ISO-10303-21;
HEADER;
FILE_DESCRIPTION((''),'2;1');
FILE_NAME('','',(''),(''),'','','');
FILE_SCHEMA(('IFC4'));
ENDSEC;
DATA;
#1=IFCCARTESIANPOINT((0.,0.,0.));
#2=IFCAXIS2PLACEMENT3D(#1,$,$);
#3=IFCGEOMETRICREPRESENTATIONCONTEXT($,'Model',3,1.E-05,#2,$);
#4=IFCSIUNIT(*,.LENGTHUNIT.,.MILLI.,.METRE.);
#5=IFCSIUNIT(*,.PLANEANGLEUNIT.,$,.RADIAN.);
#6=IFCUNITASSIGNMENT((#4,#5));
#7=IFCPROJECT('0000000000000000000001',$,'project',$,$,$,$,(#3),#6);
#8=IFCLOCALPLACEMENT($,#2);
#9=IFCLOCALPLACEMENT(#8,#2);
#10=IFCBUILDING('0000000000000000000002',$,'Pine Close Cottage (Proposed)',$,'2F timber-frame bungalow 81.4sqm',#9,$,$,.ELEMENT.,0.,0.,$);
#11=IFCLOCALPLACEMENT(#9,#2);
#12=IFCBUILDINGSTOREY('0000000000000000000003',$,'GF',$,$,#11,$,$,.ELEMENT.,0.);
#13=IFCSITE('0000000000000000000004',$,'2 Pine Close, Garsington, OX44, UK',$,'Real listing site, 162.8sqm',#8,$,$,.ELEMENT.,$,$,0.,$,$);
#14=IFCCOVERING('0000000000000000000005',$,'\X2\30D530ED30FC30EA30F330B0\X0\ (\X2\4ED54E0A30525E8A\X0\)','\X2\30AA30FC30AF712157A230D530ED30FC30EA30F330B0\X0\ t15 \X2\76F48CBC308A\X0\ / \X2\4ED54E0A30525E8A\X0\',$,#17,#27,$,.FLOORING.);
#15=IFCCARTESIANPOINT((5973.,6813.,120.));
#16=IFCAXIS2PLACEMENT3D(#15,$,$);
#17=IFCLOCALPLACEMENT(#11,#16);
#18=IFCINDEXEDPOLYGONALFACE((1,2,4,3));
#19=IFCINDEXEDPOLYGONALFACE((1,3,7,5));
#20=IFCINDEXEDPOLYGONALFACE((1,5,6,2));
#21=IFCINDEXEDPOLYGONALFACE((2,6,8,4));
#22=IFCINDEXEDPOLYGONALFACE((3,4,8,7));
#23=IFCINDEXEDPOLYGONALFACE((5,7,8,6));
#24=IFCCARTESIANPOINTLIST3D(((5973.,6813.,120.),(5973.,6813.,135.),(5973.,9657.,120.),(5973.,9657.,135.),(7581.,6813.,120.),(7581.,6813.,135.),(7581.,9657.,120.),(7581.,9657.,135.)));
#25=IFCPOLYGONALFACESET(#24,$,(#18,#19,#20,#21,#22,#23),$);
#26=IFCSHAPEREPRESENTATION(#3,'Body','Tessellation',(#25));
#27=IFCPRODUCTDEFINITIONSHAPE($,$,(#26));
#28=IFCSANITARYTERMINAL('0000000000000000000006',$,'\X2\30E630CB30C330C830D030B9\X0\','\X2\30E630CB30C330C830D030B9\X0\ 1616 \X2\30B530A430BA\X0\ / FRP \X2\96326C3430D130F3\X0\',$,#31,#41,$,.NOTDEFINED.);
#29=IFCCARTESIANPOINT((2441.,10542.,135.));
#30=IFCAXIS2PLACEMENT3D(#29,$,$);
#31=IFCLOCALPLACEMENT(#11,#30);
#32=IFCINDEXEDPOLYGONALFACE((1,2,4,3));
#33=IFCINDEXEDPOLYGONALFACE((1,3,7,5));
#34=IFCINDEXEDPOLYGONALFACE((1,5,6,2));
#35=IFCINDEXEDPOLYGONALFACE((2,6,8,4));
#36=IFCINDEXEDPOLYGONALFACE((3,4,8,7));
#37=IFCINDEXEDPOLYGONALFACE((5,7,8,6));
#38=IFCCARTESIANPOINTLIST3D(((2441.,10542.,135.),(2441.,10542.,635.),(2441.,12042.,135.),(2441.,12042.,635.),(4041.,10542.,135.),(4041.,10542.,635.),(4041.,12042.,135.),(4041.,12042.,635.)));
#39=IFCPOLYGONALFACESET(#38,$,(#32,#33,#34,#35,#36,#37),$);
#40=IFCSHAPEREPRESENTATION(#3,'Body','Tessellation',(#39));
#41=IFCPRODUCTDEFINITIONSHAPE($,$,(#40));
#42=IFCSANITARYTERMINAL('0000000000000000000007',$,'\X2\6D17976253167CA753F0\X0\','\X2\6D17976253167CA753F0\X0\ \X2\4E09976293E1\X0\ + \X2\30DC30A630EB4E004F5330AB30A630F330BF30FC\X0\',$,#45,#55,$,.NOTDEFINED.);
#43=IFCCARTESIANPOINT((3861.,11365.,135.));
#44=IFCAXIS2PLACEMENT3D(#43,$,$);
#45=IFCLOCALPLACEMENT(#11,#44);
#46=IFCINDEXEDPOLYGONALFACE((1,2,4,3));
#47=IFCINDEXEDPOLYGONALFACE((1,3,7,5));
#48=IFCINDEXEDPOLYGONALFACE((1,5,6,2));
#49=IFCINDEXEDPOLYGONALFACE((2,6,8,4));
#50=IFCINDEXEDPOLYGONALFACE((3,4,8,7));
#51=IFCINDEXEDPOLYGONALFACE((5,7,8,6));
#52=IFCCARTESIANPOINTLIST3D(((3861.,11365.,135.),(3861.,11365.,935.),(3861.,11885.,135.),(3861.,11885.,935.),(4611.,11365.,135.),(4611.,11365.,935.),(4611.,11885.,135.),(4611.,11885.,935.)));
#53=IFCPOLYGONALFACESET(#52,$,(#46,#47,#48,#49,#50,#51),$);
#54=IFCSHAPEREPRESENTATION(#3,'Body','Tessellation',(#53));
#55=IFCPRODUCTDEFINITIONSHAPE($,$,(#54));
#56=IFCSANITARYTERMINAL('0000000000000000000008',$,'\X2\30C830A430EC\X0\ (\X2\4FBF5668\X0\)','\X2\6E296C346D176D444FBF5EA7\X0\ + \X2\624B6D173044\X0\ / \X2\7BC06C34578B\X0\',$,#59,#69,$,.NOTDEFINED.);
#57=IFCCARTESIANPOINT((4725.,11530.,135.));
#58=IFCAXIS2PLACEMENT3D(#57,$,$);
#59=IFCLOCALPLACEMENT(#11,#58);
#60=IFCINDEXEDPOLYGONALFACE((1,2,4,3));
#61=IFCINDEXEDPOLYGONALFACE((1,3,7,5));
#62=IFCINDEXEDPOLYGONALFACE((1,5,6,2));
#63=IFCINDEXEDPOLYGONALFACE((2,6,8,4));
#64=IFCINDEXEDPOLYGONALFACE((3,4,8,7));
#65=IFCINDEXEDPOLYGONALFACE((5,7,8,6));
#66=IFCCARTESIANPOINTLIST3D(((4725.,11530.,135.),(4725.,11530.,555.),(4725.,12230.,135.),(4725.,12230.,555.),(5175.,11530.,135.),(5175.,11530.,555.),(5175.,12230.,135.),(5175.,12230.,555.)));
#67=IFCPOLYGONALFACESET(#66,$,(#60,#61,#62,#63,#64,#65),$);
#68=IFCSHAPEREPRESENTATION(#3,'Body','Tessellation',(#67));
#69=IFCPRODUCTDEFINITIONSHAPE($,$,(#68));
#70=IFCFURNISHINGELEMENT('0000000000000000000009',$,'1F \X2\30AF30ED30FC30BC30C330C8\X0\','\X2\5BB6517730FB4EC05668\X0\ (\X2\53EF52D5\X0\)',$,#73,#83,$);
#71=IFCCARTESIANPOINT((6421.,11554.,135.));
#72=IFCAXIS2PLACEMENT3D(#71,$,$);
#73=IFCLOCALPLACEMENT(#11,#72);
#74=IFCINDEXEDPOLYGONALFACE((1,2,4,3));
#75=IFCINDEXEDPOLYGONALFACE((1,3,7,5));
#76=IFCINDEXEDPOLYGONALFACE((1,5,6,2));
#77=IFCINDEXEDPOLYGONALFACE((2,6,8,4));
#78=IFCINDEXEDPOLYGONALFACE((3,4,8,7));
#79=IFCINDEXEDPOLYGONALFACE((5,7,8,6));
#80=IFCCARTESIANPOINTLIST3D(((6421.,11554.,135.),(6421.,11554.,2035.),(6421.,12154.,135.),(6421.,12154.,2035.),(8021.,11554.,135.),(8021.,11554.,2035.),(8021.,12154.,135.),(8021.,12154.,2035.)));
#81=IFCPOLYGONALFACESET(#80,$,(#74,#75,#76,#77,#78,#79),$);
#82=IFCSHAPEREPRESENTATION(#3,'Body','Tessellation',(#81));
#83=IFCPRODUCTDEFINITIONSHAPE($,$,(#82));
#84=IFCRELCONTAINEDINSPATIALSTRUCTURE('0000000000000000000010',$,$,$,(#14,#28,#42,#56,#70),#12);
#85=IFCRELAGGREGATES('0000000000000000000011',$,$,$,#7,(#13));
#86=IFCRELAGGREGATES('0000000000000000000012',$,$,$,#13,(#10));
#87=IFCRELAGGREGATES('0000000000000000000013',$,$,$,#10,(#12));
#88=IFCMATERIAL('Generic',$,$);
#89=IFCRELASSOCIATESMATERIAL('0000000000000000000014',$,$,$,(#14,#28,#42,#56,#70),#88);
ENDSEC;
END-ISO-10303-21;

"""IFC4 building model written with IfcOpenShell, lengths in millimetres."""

from ifc_helpers import new_model, si_unit, frame, frame_2d, origin, place, context, project, spatial, rectangle, extrude, material, element, save


model = new_model("IFC4")

# Units and contexts
model_context = context("Model", 3, precision=1e-05, world=origin())
ifc_project = project(units=[si_unit("LENGTHUNIT", "METRE", prefix="MILLI"), si_unit("PLANEANGLEUNIT", "RADIAN")], contexts=[model_context])

# Site, building, storey
site_placement = place(None, origin())
site = spatial("IfcSite", under=ifc_project, at=site_placement, Name="2 Pine Close, Garsington, OX44, UK", ObjectType="Real listing site, 162.8sqm", CompositionType="ELEMENT", RefElevation=0.0)
building_placement = place(site_placement, origin())
building = spatial("IfcBuilding", under=site, at=building_placement, Name="Pine Close Cottage (Proposed)", ObjectType="2F timber-frame bungalow 81.4sqm", CompositionType="ELEMENT", ElevationOfRefHeight=0.0, ElevationOfTerrain=0.0)
storey_placement = place(building_placement, origin())
storey = spatial("IfcBuildingStorey", under=building, at=storey_placement, Name="GF", CompositionType="ELEMENT", Elevation=0.0)

# Covering
ifc_material_1 = material(Name="Generic")
covering_1_placement = place(storey_placement, frame((5973.0, 6813.0, 120.0)))
element("IfcCovering", 1, at=covering_1_placement, inside=storey, material=ifc_material_1, Name="フローリング (仕上げ床)", Description="オーク無垢フローリング t15 直貼り / 仕上げ床", PredefinedType="FLOORING", context=model_context, shape_type="SweptSolid", body=[
    extrude(rectangle(XDim=1608.0, YDim=2844.0, at=frame_2d((804.0, 1422.0))), frame((5973.0, 6813.0, 120.0)), (0.0, 0.0, 1.0), 15.0),
])

# Sanitary terminals
sanitary_terminal_1_placement = place(storey_placement, frame((2441.0, 10542.0, 135.0)))
element("IfcSanitaryTerminal", 2, at=sanitary_terminal_1_placement, inside=storey, material=ifc_material_1, Name="ユニットバス", Description="ユニットバス 1616 サイズ / FRP 防水パン", PredefinedType="NOTDEFINED", context=model_context, shape_type="SweptSolid", body=[
    extrude(rectangle(XDim=1600.0, YDim=1500.0, at=frame_2d((800.0, 750.0))), frame((2441.0, 10542.0, 135.0)), (0.0, 0.0, 1.0), 500.0),
])
sanitary_terminal_2_placement = place(storey_placement, frame((3861.0, 11365.0, 135.0)))
element("IfcSanitaryTerminal", 3, at=sanitary_terminal_2_placement, inside=storey, material=ifc_material_1, Name="洗面化粧台", Description="洗面化粧台 三面鏡 + ボウル一体カウンター", PredefinedType="NOTDEFINED", context=model_context, shape_type="SweptSolid", body=[
    extrude(rectangle(XDim=750.0, YDim=520.0, at=frame_2d((375.0, 260.0))), frame((3861.0, 11365.0, 135.0)), (0.0, 0.0, 1.0), 800.0),
])
sanitary_terminal_3_placement = place(storey_placement, frame((4725.0, 11530.0, 135.0)))
element("IfcSanitaryTerminal", 4, at=sanitary_terminal_3_placement, inside=storey, material=ifc_material_1, Name="トイレ (便器)", Description="温水洗浄便座 + 手洗い / 節水型", PredefinedType="NOTDEFINED", context=model_context, shape_type="SweptSolid", body=[
    extrude(rectangle(XDim=450.0, YDim=700.0, at=frame_2d((225.0, 350.0))), frame((4725.0, 11530.0, 135.0)), (0.0, 0.0, 1.0), 420.0),
])

# Furnishing element
furnishing_placement = place(storey_placement, frame((6421.0, 11554.0, 135.0)))
element("IfcFurnishingElement", 5, at=furnishing_placement, inside=storey, material=ifc_material_1, Name="1F クローゼット", Description="家具・什器 (可動)", context=model_context, shape_type="SweptSolid", body=[
    extrude(rectangle(XDim=1600.0, YDim=600.0, at=frame_2d((800.0, 300.0))), frame((6421.0, 11554.0, 135.0)), (0.0, 0.0, 1.0), 1900.0),
])

save(model, "model.ifc")
